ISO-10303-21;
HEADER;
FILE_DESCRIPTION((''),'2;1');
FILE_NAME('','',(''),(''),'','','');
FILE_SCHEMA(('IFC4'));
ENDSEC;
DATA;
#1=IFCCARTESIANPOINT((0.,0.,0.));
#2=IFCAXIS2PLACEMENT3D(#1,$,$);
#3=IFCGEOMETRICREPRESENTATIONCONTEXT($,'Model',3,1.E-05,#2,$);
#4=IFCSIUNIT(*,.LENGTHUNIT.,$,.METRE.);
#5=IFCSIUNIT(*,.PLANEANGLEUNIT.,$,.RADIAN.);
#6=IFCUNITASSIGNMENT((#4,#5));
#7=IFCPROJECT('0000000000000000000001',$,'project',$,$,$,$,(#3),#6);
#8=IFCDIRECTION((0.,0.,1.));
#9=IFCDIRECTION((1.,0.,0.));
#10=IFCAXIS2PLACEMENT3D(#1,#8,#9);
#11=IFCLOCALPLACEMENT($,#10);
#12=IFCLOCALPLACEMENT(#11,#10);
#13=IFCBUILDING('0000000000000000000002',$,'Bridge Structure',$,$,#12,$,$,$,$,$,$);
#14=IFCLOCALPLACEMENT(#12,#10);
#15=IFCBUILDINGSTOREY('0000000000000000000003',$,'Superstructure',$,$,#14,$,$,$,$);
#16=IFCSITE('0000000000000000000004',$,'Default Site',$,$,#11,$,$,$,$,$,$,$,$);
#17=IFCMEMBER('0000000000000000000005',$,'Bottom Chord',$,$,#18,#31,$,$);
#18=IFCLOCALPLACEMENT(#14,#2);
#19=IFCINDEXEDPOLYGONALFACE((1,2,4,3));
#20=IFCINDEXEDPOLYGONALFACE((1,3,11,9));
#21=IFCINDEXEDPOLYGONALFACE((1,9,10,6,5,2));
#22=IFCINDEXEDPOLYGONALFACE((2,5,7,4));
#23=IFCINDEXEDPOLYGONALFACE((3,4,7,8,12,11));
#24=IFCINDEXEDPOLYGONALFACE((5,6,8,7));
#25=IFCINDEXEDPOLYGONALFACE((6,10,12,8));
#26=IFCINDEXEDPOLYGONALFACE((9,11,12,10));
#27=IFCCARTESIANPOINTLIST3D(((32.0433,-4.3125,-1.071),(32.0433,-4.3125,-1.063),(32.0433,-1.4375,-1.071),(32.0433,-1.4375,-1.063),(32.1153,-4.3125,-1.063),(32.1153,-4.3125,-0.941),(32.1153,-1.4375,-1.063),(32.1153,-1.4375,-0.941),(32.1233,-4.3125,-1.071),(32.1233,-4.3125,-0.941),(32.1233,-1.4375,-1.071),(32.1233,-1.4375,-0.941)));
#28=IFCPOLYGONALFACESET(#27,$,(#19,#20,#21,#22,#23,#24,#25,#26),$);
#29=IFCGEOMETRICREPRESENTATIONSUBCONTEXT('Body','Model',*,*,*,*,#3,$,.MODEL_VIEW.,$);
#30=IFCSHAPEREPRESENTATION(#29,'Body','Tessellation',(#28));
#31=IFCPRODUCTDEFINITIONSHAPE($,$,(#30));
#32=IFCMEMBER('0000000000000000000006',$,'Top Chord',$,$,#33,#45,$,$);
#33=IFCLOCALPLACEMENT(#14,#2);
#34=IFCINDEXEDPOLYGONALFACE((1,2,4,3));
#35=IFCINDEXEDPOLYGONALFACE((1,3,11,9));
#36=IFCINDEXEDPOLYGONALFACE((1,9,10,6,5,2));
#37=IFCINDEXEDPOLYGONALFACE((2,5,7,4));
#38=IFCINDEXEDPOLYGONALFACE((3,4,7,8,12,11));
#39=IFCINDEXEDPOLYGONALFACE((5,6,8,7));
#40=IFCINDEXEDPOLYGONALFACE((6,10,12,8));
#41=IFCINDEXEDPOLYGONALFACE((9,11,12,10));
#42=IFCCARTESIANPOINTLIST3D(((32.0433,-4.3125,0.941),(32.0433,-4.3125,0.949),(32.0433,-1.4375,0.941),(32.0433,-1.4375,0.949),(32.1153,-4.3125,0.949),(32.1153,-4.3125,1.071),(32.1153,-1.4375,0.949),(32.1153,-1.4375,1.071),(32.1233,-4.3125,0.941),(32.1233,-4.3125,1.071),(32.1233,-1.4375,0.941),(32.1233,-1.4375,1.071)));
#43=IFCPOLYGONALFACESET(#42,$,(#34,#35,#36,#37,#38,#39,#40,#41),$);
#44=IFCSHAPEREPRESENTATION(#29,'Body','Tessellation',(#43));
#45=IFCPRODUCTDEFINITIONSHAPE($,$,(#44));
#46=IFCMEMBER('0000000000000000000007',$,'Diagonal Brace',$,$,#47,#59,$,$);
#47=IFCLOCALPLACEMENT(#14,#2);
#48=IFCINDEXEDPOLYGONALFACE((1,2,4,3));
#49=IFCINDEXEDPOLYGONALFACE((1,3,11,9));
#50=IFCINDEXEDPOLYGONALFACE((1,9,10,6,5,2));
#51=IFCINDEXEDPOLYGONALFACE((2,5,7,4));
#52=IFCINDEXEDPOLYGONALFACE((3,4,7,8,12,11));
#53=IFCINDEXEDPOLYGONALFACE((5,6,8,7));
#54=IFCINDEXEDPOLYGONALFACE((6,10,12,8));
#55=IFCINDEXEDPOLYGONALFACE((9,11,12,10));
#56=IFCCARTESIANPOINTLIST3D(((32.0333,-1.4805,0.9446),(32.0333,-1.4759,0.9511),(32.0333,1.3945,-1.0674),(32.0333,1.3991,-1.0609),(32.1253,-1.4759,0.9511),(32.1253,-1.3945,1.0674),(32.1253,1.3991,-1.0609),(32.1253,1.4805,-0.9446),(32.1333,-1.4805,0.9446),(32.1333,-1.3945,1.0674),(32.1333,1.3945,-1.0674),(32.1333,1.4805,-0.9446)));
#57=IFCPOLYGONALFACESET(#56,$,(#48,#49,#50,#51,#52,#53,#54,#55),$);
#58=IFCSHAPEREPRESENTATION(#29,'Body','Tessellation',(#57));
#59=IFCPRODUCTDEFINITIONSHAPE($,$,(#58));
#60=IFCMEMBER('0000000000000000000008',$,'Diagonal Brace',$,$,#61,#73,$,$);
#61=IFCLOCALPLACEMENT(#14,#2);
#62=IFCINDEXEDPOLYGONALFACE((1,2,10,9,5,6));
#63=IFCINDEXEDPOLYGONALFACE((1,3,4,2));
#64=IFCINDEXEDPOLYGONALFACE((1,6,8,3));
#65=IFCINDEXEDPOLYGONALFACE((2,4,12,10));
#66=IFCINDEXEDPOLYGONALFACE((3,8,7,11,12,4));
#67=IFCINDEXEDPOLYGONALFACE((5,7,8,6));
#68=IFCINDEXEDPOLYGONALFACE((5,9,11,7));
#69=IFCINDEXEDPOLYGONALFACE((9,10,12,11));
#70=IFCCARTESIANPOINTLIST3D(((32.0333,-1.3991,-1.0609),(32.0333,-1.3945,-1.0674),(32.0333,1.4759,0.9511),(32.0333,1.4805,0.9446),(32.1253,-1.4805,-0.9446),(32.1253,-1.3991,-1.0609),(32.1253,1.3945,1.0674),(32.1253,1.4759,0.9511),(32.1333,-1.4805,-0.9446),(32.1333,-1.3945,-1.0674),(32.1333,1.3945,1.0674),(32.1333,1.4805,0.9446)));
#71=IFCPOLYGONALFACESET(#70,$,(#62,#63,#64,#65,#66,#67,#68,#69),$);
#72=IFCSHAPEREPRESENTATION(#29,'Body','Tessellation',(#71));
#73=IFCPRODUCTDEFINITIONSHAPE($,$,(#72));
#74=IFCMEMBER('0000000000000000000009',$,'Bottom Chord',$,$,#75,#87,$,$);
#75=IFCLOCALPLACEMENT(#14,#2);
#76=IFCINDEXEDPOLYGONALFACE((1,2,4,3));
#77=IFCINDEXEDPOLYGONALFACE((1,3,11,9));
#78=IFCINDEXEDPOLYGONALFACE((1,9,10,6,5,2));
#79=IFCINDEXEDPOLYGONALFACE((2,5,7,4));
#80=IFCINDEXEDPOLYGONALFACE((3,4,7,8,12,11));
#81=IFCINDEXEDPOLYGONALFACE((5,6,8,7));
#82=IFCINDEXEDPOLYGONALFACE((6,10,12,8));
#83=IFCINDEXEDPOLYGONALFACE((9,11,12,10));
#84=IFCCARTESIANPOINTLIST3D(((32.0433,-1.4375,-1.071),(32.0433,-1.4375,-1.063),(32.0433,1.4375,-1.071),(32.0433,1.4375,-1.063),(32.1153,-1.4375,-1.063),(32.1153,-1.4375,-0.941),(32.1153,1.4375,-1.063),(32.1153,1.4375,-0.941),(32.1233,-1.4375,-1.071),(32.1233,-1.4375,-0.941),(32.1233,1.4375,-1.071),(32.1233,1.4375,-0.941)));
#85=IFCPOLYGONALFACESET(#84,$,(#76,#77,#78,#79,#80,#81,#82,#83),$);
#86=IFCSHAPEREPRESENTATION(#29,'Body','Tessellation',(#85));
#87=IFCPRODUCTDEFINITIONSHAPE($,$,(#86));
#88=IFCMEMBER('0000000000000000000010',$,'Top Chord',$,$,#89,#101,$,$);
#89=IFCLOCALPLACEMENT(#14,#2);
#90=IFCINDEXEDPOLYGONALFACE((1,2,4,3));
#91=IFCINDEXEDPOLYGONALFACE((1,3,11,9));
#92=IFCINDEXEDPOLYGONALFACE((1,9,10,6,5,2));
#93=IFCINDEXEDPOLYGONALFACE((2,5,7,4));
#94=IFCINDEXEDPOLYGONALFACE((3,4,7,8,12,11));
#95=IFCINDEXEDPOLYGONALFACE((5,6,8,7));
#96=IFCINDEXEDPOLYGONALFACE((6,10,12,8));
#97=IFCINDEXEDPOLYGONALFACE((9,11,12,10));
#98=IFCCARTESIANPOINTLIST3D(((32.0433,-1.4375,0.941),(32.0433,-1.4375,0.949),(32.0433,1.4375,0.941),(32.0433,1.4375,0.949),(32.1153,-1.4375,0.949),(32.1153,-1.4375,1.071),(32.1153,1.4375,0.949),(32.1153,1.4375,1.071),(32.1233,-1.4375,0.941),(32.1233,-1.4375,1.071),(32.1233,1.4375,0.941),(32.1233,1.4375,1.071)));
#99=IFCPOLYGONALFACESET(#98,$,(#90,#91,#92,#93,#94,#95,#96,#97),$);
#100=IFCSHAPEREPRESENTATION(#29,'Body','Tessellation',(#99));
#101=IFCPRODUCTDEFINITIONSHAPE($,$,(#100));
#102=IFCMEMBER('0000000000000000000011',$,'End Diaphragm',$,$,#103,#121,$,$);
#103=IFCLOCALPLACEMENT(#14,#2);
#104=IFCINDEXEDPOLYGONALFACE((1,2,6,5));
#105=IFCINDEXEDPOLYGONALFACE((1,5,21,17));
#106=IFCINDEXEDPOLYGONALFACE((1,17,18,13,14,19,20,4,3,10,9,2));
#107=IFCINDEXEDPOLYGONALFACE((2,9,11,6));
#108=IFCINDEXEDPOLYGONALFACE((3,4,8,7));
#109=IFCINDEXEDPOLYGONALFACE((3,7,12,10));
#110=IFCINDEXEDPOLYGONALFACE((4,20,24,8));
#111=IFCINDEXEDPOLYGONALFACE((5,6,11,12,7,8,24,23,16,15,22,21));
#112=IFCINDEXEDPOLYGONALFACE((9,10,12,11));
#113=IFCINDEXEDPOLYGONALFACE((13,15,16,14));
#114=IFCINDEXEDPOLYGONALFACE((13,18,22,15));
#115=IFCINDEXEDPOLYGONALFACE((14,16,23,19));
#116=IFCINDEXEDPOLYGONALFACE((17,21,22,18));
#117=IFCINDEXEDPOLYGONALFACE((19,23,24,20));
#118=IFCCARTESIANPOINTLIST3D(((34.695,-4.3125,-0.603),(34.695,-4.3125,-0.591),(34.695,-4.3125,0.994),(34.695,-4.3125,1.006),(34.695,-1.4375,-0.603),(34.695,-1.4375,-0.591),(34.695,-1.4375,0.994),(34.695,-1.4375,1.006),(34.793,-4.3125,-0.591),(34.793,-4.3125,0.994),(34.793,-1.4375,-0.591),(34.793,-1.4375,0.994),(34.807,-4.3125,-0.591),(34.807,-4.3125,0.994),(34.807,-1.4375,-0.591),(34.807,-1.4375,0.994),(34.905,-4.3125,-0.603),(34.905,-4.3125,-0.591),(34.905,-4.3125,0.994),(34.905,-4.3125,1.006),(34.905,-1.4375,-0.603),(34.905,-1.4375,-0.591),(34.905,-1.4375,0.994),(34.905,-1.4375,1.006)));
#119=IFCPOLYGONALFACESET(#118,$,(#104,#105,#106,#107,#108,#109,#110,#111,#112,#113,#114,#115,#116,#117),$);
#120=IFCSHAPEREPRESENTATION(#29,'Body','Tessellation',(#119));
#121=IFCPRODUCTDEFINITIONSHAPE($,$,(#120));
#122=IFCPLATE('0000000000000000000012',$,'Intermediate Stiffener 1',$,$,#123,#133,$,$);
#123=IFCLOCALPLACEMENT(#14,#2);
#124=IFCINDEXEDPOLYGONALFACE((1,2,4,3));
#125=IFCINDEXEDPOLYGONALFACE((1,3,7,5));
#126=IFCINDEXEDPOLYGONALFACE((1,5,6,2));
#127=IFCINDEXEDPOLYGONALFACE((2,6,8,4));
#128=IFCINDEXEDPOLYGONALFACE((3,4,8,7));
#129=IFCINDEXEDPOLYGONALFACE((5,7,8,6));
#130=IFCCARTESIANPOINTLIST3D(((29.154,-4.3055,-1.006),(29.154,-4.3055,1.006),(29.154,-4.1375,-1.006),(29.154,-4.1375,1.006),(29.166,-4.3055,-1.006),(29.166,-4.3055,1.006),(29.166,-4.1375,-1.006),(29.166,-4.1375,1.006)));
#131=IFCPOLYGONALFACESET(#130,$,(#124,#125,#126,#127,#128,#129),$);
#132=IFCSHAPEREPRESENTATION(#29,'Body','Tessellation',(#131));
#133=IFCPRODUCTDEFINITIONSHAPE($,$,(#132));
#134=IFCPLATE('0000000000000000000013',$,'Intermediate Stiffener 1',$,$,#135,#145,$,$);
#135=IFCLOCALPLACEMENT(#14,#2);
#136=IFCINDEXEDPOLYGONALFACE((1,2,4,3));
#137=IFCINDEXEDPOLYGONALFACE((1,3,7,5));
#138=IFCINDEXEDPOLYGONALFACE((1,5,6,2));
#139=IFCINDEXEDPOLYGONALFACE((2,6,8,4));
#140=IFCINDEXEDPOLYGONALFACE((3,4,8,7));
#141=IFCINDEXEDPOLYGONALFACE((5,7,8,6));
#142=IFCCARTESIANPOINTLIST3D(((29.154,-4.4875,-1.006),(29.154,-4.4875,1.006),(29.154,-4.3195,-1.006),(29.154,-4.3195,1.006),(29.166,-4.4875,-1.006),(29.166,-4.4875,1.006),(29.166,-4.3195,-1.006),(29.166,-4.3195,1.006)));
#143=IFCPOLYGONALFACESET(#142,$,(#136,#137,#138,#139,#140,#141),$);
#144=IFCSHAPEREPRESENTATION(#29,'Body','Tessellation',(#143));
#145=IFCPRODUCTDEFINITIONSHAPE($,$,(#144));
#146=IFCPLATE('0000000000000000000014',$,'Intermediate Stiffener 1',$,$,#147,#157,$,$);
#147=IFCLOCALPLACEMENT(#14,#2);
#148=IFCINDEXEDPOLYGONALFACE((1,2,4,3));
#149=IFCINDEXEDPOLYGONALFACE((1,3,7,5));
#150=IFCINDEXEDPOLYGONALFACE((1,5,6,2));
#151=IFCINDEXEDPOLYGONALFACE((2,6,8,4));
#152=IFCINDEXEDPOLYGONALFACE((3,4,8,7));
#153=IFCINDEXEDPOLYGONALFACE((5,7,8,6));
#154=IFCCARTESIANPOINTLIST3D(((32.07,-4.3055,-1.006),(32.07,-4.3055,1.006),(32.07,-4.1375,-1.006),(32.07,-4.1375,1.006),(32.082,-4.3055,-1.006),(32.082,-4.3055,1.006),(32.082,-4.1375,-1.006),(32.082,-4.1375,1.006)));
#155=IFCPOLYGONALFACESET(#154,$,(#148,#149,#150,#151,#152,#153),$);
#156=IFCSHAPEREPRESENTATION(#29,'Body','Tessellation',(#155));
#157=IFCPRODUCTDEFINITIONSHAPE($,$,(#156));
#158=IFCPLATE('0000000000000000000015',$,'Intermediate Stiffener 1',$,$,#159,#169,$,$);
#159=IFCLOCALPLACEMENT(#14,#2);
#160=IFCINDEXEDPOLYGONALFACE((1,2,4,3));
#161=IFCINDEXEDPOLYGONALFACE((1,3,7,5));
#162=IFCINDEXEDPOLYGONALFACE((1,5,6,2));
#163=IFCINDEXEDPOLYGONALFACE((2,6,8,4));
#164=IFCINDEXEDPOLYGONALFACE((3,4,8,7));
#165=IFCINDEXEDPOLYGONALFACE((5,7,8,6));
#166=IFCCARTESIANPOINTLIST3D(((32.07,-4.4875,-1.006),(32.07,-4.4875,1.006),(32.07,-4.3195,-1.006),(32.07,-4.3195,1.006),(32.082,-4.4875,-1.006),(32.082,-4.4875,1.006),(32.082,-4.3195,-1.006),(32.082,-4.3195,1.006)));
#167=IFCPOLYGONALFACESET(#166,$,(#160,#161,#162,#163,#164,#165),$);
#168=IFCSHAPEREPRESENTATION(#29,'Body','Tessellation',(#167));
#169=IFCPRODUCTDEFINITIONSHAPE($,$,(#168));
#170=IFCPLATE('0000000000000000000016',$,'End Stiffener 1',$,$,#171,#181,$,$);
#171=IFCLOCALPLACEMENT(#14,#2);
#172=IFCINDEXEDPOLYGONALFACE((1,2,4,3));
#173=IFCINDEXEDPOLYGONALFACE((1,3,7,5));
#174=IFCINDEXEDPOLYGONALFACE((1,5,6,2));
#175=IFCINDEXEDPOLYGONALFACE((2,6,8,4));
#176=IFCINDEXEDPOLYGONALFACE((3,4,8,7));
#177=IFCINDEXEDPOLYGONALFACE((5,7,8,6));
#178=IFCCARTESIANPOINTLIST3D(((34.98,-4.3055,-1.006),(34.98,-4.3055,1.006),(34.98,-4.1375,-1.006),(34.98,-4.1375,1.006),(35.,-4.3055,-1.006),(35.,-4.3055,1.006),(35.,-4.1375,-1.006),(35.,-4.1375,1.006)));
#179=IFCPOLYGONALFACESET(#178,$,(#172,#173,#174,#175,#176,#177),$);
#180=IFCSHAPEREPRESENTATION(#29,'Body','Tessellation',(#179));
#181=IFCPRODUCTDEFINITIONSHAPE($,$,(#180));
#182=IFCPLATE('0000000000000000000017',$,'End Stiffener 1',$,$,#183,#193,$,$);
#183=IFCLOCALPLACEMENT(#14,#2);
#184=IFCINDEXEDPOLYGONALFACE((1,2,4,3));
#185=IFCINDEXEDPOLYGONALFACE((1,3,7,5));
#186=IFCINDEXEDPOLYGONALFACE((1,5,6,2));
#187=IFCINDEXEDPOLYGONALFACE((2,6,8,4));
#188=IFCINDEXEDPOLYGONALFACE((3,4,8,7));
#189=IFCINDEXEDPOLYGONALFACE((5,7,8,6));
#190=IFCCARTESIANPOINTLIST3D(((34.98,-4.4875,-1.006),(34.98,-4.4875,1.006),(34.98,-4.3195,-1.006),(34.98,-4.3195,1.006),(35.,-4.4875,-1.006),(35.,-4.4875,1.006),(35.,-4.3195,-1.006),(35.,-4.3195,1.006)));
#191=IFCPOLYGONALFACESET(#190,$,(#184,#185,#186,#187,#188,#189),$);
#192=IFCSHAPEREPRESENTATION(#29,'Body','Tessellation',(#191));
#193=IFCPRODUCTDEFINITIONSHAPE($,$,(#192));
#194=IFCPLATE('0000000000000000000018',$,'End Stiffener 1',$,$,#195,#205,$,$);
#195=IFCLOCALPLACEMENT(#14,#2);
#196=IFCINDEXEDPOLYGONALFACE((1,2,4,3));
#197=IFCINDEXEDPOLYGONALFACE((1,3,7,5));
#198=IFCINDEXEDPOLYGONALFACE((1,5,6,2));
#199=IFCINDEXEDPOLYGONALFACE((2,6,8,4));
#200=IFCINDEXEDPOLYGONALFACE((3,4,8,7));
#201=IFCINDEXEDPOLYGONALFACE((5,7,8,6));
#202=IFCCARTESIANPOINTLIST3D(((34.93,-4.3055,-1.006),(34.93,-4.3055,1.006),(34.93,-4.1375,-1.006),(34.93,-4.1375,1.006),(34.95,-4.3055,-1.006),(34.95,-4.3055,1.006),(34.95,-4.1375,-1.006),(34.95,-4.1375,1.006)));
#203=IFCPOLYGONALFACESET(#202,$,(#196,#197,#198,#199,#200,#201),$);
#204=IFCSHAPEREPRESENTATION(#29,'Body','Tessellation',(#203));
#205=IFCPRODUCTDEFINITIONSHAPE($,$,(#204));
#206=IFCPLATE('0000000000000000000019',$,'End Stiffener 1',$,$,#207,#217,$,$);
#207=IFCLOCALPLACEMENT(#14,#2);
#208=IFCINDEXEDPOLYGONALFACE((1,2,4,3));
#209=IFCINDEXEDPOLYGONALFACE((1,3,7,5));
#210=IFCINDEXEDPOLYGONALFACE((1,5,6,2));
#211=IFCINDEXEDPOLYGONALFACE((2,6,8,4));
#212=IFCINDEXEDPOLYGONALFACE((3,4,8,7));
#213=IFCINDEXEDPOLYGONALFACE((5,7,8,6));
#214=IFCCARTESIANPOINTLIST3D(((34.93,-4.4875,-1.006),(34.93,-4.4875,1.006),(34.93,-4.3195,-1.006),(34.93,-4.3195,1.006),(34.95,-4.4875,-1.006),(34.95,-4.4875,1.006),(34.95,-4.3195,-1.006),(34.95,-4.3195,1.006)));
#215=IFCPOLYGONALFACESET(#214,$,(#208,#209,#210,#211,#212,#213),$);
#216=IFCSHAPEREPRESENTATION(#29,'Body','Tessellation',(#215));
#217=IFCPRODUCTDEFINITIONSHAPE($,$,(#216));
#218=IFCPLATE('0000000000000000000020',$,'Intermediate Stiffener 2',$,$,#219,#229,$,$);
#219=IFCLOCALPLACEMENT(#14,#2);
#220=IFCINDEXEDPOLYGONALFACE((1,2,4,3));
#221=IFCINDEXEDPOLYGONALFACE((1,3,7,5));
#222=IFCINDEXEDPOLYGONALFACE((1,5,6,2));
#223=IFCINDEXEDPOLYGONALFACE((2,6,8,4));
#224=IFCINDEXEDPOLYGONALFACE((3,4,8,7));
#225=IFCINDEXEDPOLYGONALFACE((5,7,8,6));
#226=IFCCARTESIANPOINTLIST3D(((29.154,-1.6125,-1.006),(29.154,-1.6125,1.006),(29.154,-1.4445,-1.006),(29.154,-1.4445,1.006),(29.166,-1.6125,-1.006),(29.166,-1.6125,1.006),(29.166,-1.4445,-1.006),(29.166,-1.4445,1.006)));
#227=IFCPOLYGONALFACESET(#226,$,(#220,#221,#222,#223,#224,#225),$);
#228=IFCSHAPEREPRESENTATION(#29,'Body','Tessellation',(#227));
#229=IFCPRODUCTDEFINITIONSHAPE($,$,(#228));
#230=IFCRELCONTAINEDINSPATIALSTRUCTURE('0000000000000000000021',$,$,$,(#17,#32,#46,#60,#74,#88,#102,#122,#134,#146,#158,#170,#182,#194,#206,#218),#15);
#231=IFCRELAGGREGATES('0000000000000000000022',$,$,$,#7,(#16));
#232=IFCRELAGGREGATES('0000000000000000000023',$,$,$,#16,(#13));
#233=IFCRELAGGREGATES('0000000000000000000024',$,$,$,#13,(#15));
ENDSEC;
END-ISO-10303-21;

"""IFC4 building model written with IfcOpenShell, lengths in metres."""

from ifc_helpers import new_model, si_unit, frame, origin, origin_with_axes, origin_2d_with_axis, place, context, subcontext, project, spatial, rectangle, i_section, l_section, extrude, element, save


model = new_model("IFC4")

# Units and contexts
model_context = context("Model", 3, precision=1e-05, world=origin())
body_context = subcontext(model_context, "Body", "Model", "MODEL_VIEW")
ifc_project = project(units=[si_unit("LENGTHUNIT", "METRE"), si_unit("PLANEANGLEUNIT", "RADIAN")], contexts=[model_context])

# Site, building, storey
site_placement = place(None, origin_with_axes())
site = spatial("IfcSite", under=ifc_project, at=site_placement, Name="Default Site")
building_placement = place(site_placement, origin_with_axes())
building = spatial("IfcBuilding", under=site, at=building_placement, Name="Bridge Structure")
storey_placement = place(building_placement, origin_with_axes())
storey = spatial("IfcBuildingStorey", under=building, at=storey_placement, Name="Superstructure")

# Members
for number, where, z_axis, x_axis, name in (
    (1, (32.0833, -4.3125, -1.006), (0.0, 1.0, 0.0), (-1.0, 0.0, 0.0), "Bottom Chord"),
    (2, (32.0833, -4.3125, 1.006), (0.0, 1.0, 0.0), (-1.0, 0.0, 0.0), "Top Chord"),
):
    element("IfcMember", number, at=place(storey_placement, frame(where, z_axis=z_axis, x_axis=x_axis)), inside=storey, Name=name, context=body_context, shape_type="SweptSolid", body=[
        extrude(l_section(Depth=0.13, Width=0.08, Thickness=0.008, at=origin_2d_with_axis()), origin_with_axes(), (0.0, 0.0, 1.0), 2.875),
    ])
for number, where, z_axis, x_axis, name in (
    (3, (32.0833, -1.4375, 1.006), (0.0, 0.819299, -0.573367), (-1.0, 0.0, 0.0), "Diagonal Brace"),
    (4, (32.0833, -1.4375, -1.006), (0.0, 0.819299, 0.573367), (-1.0, 0.0, 0.0), "Diagonal Brace"),
):
    element("IfcMember", number, at=place(storey_placement, frame(where, z_axis=z_axis, x_axis=x_axis)), inside=storey, Name=name, context=body_context, shape_type="SweptSolid", body=[
        extrude(l_section(Depth=0.15, Width=0.1, Thickness=0.008, at=origin_2d_with_axis()), origin_with_axes(), (0.0, 0.0, 1.0), 3.5091),
    ])
for number, where, z_axis, x_axis, name in (
    (5, (32.0833, -1.4375, -1.006), (0.0, 1.0, 0.0), (-1.0, 0.0, 0.0), "Bottom Chord"),
    (6, (32.0833, -1.4375, 1.006), (0.0, 1.0, 0.0), (-1.0, 0.0, 0.0), "Top Chord"),
):
    element("IfcMember", number, at=place(storey_placement, frame(where, z_axis=z_axis, x_axis=x_axis)), inside=storey, Name=name, context=body_context, shape_type="SweptSolid", body=[
        extrude(l_section(Depth=0.13, Width=0.08, Thickness=0.008, at=origin_2d_with_axis()), origin_with_axes(), (0.0, 0.0, 1.0), 2.875),
    ])
member_1_placement = place(storey_placement, frame((34.8, -4.3125, 0.2015), z_axis=(0.0, 1.0, 0.0), x_axis=(-1.0, 0.0, 0.0)))
element("IfcMember", 7, at=member_1_placement, inside=storey, Name="End Diaphragm", context=body_context, shape_type="SweptSolid", body=[
    extrude(i_section(OverallWidth=0.21, OverallDepth=1.609, WebThickness=0.014, FlangeThickness=0.012, at=origin_2d_with_axis()), origin_with_axes(), (0.0, 0.0, 1.0), 2.875),
])

# Plates
for number, where, z_axis, x_axis, name in (
    (8, (29.16, -4.2215, -1.006), (0.0, 0.0, 1.0), (1.0, 0.0, 0.0), "Intermediate Stiffener 1"),
    (9, (29.16, -4.4035, -1.006), (0.0, 0.0, 1.0), (1.0, 0.0, 0.0), "Intermediate Stiffener 1"),
    (10, (32.076, -4.2215, -1.006), (0.0, 0.0, 1.0), (1.0, 0.0, 0.0), "Intermediate Stiffener 1"),
    (11, (32.076, -4.4035, -1.006), (0.0, 0.0, 1.0), (1.0, 0.0, 0.0), "Intermediate Stiffener 1"),
):
    element("IfcPlate", number, at=place(storey_placement, frame(where, z_axis=z_axis, x_axis=x_axis)), inside=storey, Name=name, context=body_context, shape_type="SweptSolid", body=[
        extrude(rectangle(XDim=0.012, YDim=0.168, at=origin_2d_with_axis()), origin_with_axes(), (0.0, 0.0, 1.0), 2.012),
    ])
for number, where, z_axis, x_axis, name in (
    (12, (34.99, -4.2215, -1.006), (0.0, 0.0, 1.0), (1.0, 0.0, 0.0), "End Stiffener 1"),
    (13, (34.99, -4.4035, -1.006), (0.0, 0.0, 1.0), (1.0, 0.0, 0.0), "End Stiffener 1"),
    (14, (34.94, -4.2215, -1.006), (0.0, 0.0, 1.0), (1.0, 0.0, 0.0), "End Stiffener 1"),
    (15, (34.94, -4.4035, -1.006), (0.0, 0.0, 1.0), (1.0, 0.0, 0.0), "End Stiffener 1"),
):
    element("IfcPlate", number, at=place(storey_placement, frame(where, z_axis=z_axis, x_axis=x_axis)), inside=storey, Name=name, context=body_context, shape_type="SweptSolid", body=[
        extrude(rectangle(XDim=0.02, YDim=0.168, at=origin_2d_with_axis()), origin_with_axes(), (0.0, 0.0, 1.0), 2.012),
    ])
for number, where, z_axis, x_axis, name in (
    (16, (29.16, -1.5285, -1.006), (0.0, 0.0, 1.0), (1.0, 0.0, 0.0), "Intermediate Stiffener 2"),
):
    element("IfcPlate", number, at=place(storey_placement, frame(where, z_axis=z_axis, x_axis=x_axis)), inside=storey, Name=name, context=body_context, shape_type="SweptSolid", body=[
        extrude(rectangle(XDim=0.012, YDim=0.168, at=origin_2d_with_axis()), origin_with_axes(), (0.0, 0.0, 1.0), 2.012),
    ])

save(model, "model.ifc")
